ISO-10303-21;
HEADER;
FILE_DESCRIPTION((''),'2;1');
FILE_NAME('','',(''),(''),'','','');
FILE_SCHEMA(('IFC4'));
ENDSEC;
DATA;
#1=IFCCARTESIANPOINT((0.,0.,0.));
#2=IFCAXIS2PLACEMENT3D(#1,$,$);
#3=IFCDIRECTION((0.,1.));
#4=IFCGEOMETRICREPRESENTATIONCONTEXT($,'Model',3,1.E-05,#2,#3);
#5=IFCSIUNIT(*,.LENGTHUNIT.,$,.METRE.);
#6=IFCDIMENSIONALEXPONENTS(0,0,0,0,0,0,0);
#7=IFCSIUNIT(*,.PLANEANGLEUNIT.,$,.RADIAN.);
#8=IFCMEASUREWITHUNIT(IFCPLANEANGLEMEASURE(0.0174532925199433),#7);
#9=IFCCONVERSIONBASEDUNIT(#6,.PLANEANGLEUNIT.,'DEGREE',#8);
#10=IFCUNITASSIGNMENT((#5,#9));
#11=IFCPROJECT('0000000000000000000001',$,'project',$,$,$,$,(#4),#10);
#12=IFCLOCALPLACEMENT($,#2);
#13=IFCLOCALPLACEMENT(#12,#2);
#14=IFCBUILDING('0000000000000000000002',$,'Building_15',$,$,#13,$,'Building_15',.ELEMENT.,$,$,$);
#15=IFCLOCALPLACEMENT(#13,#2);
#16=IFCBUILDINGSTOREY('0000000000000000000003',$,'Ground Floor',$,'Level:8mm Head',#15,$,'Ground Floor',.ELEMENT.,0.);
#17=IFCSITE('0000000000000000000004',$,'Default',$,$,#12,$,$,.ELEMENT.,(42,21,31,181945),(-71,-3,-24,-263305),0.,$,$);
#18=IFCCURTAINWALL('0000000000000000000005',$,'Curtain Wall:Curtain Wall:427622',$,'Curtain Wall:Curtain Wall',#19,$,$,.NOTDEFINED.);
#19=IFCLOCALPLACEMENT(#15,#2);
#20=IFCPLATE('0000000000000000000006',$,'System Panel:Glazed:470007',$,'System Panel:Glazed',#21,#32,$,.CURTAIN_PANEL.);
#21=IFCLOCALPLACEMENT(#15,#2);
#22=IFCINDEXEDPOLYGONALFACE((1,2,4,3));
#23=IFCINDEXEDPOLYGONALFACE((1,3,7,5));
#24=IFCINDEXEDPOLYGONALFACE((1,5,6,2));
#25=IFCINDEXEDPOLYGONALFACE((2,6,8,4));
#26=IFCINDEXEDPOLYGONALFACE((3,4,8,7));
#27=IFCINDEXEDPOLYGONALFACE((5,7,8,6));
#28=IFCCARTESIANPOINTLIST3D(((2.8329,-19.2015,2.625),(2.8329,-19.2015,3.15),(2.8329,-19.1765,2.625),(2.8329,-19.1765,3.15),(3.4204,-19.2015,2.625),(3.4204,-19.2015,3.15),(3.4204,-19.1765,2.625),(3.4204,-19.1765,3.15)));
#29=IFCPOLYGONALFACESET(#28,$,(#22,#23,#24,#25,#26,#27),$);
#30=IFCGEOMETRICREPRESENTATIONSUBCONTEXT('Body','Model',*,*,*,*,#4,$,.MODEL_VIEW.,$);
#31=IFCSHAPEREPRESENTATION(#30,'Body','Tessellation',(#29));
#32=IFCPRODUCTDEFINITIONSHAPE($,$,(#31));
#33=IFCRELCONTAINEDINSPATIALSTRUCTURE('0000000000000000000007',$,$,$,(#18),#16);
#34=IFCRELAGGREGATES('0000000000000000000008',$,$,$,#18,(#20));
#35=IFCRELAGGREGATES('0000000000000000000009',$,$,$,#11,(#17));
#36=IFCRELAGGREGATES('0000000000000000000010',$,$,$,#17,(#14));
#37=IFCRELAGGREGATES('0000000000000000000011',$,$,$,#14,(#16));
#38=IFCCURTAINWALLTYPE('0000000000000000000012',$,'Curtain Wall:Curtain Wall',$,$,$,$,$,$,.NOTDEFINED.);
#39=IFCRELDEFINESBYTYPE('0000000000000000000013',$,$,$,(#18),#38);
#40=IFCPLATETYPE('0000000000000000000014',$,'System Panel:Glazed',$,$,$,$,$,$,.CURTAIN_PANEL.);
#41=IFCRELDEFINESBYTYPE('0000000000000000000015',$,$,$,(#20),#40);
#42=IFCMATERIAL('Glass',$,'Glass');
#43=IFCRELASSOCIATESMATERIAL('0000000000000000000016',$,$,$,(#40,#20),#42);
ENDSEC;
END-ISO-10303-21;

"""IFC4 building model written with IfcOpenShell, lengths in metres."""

from ifc_helpers import new_model, entity, si_unit, converted_unit, direction, frame, origin, place, context, subcontext, project, spatial, indexed_curve, outline, extrude, source, transform, mapped, material, type_object, type_shapes, element, aggregate, save


model = new_model("IFC4")

# Units and contexts
model_context = context("Model", 3, precision=1e-05, world=origin(), true_north=direction((0.0, 1.0)))
body_context = subcontext(model_context, "Body", "Model", "MODEL_VIEW")
ifc_project = project(units=[si_unit("LENGTHUNIT", "METRE"), converted_unit("PLANEANGLEUNIT", "DEGREE", entity("IfcPlaneAngleMeasure", 0.0174532925199433), si_unit("PLANEANGLEUNIT", "RADIAN"), dimensions=[0, 0, 0, 0, 0, 0, 0])], contexts=[model_context])

# Site, building, storey
site_placement = place(None, origin())
site = spatial("IfcSite", under=ifc_project, at=site_placement, Name="Default", CompositionType="ELEMENT", RefLatitude=(42, 21, 31, 181945), RefLongitude=(-71, -3, -24, -263305), RefElevation=0.0)
building_placement = place(site_placement, origin())
building = spatial("IfcBuilding", under=site, at=building_placement, Name="Building_15", LongName="Building_15", CompositionType="ELEMENT")
storey_placement = place(building_placement, origin())
storey = spatial("IfcBuildingStorey", under=building, at=storey_placement, Name="Ground Floor", ObjectType="Level:8mm Head", LongName="Ground Floor", CompositionType="ELEMENT", Elevation=0.0)

# Curtain wall, plate
curtain_wall_type_1 = type_object("IfcCurtainWallType", Name="Curtain Wall:Curtain Wall", PredefinedType="NOTDEFINED")
curtain_wall_1_placement = place(storey_placement, origin())
curtain_wall_1 = element("IfcCurtainWall", 1, at=curtain_wall_1_placement, inside=storey, type_object=curtain_wall_type_1, Name="Curtain Wall:Curtain Wall:427622", ObjectType="Curtain Wall:Curtain Wall", PredefinedType="NOTDEFINED")
ifc_material_1 = material(Name="Glass", Category="Glass")
plate_type = type_object("IfcPlateType", Name="System Panel:Glazed", PredefinedType="CURTAIN_PANEL", material=ifc_material_1)
shared_shape_1 = source(origin(), body_context, "Body", "SweptSolid", [
    extrude(outline(indexed_curve([(-0.0125, -0.2938), (0.0125, -0.2938), (0.0125, 0.2938), (-0.0125, 0.2938), (-0.0125, -0.2938)], self_intersect=False)), frame((0.0, 0.037, 0.0), z_axis=(0.0, 0.0, 1.0), x_axis=(0.0, 1.0, 0.0)), (0.0, 0.0, 1.0), 0.525),
])
type_shapes(plate_type, [shared_shape_1])
plate_1_placement = place(curtain_wall_1_placement, frame((3.1266, -19.226, 2.625)))
plate_1 = element("IfcPlate", 2, at=plate_1_placement, type_object=plate_type, material=ifc_material_1, Name="System Panel:Glazed:470007", ObjectType="System Panel:Glazed", PredefinedType="CURTAIN_PANEL", context=body_context, shape_type="MappedRepresentation", body=[
    mapped(shared_shape_1, transform((0.0, 0.0, 0.0), scale=1.0)),
])
aggregate(curtain_wall_1, [plate_1])

save(model, "model.ifc")
